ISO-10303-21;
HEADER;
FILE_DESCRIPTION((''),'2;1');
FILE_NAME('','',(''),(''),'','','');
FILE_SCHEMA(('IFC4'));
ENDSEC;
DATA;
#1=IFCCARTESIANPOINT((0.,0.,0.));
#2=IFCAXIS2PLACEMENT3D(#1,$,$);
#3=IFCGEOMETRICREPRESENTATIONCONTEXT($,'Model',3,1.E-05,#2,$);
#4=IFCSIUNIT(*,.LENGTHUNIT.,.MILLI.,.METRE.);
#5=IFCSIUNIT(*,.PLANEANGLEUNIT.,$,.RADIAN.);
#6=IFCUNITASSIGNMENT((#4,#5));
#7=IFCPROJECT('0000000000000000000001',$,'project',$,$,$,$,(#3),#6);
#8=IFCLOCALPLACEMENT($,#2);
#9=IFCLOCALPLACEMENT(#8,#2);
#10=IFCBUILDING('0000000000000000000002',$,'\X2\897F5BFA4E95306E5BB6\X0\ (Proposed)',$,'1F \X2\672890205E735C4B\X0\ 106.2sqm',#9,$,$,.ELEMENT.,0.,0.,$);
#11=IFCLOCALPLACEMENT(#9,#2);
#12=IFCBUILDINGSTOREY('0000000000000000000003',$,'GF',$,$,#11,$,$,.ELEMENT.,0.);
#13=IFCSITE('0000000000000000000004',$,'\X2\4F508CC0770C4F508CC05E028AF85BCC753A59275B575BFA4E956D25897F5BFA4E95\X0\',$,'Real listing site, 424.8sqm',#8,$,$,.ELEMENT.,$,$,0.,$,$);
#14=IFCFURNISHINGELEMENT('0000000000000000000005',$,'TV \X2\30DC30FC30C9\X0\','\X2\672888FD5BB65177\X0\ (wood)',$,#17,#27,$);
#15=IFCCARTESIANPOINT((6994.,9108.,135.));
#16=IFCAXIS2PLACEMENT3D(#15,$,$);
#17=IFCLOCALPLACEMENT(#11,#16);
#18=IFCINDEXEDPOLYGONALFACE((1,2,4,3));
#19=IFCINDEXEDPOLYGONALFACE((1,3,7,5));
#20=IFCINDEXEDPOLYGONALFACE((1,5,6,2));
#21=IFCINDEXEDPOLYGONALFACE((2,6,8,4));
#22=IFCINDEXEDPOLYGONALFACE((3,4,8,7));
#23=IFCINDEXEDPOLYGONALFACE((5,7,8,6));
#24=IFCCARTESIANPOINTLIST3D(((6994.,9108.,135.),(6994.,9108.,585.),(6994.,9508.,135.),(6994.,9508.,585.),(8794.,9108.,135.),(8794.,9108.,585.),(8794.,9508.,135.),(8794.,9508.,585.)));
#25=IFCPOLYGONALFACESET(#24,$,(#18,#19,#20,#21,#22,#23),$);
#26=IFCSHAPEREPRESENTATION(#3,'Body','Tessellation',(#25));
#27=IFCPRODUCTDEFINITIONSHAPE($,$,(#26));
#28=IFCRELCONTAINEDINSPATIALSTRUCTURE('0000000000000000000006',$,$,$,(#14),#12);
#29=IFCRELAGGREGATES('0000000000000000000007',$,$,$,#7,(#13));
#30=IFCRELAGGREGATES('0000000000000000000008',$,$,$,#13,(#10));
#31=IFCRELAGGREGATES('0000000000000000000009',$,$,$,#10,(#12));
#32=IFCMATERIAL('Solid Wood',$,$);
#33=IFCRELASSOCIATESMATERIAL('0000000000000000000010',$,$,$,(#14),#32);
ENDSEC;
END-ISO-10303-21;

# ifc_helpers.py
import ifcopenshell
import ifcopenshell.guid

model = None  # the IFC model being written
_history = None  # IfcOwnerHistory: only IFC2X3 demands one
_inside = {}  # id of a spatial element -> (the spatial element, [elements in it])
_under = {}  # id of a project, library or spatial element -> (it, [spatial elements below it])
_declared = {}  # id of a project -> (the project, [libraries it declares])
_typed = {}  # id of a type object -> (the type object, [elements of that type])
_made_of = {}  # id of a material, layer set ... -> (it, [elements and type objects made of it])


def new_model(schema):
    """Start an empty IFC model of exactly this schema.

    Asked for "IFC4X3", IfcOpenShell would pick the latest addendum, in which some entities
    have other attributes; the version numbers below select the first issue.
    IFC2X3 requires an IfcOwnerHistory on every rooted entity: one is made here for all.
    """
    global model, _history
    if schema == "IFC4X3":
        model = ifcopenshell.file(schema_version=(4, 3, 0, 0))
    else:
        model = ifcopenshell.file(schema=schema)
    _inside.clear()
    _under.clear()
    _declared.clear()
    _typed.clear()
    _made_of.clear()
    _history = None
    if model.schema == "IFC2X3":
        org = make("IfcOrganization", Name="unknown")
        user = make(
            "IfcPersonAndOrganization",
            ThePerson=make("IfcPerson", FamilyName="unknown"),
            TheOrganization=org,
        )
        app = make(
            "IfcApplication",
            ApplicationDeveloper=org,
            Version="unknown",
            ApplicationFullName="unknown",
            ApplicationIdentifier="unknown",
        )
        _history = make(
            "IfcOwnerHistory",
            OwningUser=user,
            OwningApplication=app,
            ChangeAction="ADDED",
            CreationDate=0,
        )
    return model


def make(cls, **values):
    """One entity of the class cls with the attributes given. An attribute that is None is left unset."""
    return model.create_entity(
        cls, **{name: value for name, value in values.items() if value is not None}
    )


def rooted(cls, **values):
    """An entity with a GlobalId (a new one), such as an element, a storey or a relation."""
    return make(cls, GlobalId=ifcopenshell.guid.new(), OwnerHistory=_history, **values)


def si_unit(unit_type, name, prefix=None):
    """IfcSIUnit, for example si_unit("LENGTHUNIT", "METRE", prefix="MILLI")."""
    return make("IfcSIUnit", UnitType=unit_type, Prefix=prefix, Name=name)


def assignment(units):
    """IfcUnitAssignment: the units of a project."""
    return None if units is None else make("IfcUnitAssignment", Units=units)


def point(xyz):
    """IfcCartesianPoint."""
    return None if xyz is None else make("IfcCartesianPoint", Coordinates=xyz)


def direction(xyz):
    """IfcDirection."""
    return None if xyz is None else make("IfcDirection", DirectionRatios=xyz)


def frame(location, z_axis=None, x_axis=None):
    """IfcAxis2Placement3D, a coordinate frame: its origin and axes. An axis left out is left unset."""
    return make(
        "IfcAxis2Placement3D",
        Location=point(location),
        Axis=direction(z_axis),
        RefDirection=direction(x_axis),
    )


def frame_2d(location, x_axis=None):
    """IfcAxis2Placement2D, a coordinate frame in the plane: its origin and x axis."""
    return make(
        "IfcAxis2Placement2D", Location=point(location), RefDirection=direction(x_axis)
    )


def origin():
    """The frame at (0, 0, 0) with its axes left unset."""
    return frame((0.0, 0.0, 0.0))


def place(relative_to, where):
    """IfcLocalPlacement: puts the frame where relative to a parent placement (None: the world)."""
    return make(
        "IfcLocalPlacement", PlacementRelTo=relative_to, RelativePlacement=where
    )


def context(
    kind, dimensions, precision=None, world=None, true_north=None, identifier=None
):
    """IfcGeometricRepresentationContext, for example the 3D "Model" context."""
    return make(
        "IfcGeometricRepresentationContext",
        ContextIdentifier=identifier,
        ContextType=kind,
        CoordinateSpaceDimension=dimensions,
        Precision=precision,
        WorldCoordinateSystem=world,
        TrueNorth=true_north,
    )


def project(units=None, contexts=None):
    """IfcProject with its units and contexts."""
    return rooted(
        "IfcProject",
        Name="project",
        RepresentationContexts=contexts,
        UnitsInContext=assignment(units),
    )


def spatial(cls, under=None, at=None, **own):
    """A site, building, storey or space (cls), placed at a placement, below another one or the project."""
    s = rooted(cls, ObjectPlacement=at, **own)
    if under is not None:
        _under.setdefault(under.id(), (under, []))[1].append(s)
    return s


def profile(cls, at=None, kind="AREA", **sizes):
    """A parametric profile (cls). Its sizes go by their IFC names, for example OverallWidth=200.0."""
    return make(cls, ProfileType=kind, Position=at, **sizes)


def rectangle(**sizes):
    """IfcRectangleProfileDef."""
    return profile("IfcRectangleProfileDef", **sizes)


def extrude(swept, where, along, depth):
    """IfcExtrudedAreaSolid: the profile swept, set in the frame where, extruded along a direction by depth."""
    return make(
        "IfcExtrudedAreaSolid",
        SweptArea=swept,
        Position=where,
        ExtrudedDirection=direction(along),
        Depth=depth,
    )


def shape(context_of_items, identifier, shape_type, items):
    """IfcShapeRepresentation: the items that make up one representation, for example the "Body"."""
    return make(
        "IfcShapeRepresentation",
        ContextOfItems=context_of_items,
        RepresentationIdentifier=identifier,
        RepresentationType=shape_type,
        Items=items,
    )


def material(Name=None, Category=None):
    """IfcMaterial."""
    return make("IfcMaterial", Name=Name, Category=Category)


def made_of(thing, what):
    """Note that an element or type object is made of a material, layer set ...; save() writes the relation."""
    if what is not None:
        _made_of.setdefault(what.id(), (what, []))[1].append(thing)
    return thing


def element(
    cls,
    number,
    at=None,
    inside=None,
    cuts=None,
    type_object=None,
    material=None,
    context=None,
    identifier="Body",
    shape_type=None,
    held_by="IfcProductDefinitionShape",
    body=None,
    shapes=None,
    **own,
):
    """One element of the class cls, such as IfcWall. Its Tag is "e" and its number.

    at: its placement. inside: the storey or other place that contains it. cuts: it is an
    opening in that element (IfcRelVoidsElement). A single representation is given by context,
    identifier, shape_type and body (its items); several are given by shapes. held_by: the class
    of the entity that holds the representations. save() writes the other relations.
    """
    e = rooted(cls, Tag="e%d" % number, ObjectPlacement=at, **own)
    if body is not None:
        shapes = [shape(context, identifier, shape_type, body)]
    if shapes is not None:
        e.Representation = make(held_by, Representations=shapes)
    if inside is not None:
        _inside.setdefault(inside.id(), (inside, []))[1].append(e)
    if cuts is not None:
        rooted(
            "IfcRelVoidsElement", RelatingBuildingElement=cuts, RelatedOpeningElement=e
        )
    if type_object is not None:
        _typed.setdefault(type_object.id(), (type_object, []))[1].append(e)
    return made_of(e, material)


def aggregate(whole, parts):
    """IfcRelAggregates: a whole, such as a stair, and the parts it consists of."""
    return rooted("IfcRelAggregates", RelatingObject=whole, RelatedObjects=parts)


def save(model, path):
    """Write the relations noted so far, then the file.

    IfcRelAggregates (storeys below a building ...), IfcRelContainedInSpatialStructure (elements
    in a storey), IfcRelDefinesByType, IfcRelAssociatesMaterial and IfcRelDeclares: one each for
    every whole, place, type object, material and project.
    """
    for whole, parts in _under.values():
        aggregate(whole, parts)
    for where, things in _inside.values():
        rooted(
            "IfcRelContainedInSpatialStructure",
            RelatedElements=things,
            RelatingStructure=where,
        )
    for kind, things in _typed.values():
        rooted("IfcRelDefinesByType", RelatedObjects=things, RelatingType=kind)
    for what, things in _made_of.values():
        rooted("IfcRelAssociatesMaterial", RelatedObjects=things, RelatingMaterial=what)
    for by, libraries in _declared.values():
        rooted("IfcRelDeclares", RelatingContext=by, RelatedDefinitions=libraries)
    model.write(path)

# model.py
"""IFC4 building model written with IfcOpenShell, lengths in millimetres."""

from ifc_helpers import new_model, si_unit, frame, frame_2d, origin, place, context, project, spatial, rectangle, extrude, material, element, save


model = new_model("IFC4")

# Units and contexts
model_context = context("Model", 3, precision=1e-05, world=origin())
ifc_project = project(units=[si_unit("LENGTHUNIT", "METRE", prefix="MILLI"), si_unit("PLANEANGLEUNIT", "RADIAN")], contexts=[model_context])

# Site, building, storey
site_placement = place(None, origin())
site = spatial("IfcSite", under=ifc_project, at=site_placement, Name="佐賀県佐賀市諸富町大字寺井津西寺井", ObjectType="Real listing site, 424.8sqm", CompositionType="ELEMENT", RefElevation=0.0)
building_placement = place(site_placement, origin())
building = spatial("IfcBuilding", under=site, at=building_placement, Name="西寺井の家 (Proposed)", ObjectType="1F 木造平屋 106.2sqm", CompositionType="ELEMENT", ElevationOfRefHeight=0.0, ElevationOfTerrain=0.0)
storey_placement = place(building_placement, origin())
storey = spatial("IfcBuildingStorey", under=building, at=storey_placement, Name="GF", CompositionType="ELEMENT", Elevation=0.0)

# Shared definitions
ifc_material_1 = material(Name="Solid Wood")

# Furnishing element
furnishing_1_placement = place(storey_placement, frame((6994.0, 9108.0, 135.0)))
element("IfcFurnishingElement", 1, at=furnishing_1_placement, inside=storey, material=ifc_material_1, Name="TV ボード", Description="木製家具 (wood)", context=model_context, shape_type="SweptSolid", body=[
    extrude(rectangle(XDim=1800.0, YDim=400.0, at=frame_2d((900.0, 200.0))), frame((6994.0, 9108.0, 135.0)), (0.0, 0.0, 1.0), 450.0),
])

save(model, "model.ifc")
